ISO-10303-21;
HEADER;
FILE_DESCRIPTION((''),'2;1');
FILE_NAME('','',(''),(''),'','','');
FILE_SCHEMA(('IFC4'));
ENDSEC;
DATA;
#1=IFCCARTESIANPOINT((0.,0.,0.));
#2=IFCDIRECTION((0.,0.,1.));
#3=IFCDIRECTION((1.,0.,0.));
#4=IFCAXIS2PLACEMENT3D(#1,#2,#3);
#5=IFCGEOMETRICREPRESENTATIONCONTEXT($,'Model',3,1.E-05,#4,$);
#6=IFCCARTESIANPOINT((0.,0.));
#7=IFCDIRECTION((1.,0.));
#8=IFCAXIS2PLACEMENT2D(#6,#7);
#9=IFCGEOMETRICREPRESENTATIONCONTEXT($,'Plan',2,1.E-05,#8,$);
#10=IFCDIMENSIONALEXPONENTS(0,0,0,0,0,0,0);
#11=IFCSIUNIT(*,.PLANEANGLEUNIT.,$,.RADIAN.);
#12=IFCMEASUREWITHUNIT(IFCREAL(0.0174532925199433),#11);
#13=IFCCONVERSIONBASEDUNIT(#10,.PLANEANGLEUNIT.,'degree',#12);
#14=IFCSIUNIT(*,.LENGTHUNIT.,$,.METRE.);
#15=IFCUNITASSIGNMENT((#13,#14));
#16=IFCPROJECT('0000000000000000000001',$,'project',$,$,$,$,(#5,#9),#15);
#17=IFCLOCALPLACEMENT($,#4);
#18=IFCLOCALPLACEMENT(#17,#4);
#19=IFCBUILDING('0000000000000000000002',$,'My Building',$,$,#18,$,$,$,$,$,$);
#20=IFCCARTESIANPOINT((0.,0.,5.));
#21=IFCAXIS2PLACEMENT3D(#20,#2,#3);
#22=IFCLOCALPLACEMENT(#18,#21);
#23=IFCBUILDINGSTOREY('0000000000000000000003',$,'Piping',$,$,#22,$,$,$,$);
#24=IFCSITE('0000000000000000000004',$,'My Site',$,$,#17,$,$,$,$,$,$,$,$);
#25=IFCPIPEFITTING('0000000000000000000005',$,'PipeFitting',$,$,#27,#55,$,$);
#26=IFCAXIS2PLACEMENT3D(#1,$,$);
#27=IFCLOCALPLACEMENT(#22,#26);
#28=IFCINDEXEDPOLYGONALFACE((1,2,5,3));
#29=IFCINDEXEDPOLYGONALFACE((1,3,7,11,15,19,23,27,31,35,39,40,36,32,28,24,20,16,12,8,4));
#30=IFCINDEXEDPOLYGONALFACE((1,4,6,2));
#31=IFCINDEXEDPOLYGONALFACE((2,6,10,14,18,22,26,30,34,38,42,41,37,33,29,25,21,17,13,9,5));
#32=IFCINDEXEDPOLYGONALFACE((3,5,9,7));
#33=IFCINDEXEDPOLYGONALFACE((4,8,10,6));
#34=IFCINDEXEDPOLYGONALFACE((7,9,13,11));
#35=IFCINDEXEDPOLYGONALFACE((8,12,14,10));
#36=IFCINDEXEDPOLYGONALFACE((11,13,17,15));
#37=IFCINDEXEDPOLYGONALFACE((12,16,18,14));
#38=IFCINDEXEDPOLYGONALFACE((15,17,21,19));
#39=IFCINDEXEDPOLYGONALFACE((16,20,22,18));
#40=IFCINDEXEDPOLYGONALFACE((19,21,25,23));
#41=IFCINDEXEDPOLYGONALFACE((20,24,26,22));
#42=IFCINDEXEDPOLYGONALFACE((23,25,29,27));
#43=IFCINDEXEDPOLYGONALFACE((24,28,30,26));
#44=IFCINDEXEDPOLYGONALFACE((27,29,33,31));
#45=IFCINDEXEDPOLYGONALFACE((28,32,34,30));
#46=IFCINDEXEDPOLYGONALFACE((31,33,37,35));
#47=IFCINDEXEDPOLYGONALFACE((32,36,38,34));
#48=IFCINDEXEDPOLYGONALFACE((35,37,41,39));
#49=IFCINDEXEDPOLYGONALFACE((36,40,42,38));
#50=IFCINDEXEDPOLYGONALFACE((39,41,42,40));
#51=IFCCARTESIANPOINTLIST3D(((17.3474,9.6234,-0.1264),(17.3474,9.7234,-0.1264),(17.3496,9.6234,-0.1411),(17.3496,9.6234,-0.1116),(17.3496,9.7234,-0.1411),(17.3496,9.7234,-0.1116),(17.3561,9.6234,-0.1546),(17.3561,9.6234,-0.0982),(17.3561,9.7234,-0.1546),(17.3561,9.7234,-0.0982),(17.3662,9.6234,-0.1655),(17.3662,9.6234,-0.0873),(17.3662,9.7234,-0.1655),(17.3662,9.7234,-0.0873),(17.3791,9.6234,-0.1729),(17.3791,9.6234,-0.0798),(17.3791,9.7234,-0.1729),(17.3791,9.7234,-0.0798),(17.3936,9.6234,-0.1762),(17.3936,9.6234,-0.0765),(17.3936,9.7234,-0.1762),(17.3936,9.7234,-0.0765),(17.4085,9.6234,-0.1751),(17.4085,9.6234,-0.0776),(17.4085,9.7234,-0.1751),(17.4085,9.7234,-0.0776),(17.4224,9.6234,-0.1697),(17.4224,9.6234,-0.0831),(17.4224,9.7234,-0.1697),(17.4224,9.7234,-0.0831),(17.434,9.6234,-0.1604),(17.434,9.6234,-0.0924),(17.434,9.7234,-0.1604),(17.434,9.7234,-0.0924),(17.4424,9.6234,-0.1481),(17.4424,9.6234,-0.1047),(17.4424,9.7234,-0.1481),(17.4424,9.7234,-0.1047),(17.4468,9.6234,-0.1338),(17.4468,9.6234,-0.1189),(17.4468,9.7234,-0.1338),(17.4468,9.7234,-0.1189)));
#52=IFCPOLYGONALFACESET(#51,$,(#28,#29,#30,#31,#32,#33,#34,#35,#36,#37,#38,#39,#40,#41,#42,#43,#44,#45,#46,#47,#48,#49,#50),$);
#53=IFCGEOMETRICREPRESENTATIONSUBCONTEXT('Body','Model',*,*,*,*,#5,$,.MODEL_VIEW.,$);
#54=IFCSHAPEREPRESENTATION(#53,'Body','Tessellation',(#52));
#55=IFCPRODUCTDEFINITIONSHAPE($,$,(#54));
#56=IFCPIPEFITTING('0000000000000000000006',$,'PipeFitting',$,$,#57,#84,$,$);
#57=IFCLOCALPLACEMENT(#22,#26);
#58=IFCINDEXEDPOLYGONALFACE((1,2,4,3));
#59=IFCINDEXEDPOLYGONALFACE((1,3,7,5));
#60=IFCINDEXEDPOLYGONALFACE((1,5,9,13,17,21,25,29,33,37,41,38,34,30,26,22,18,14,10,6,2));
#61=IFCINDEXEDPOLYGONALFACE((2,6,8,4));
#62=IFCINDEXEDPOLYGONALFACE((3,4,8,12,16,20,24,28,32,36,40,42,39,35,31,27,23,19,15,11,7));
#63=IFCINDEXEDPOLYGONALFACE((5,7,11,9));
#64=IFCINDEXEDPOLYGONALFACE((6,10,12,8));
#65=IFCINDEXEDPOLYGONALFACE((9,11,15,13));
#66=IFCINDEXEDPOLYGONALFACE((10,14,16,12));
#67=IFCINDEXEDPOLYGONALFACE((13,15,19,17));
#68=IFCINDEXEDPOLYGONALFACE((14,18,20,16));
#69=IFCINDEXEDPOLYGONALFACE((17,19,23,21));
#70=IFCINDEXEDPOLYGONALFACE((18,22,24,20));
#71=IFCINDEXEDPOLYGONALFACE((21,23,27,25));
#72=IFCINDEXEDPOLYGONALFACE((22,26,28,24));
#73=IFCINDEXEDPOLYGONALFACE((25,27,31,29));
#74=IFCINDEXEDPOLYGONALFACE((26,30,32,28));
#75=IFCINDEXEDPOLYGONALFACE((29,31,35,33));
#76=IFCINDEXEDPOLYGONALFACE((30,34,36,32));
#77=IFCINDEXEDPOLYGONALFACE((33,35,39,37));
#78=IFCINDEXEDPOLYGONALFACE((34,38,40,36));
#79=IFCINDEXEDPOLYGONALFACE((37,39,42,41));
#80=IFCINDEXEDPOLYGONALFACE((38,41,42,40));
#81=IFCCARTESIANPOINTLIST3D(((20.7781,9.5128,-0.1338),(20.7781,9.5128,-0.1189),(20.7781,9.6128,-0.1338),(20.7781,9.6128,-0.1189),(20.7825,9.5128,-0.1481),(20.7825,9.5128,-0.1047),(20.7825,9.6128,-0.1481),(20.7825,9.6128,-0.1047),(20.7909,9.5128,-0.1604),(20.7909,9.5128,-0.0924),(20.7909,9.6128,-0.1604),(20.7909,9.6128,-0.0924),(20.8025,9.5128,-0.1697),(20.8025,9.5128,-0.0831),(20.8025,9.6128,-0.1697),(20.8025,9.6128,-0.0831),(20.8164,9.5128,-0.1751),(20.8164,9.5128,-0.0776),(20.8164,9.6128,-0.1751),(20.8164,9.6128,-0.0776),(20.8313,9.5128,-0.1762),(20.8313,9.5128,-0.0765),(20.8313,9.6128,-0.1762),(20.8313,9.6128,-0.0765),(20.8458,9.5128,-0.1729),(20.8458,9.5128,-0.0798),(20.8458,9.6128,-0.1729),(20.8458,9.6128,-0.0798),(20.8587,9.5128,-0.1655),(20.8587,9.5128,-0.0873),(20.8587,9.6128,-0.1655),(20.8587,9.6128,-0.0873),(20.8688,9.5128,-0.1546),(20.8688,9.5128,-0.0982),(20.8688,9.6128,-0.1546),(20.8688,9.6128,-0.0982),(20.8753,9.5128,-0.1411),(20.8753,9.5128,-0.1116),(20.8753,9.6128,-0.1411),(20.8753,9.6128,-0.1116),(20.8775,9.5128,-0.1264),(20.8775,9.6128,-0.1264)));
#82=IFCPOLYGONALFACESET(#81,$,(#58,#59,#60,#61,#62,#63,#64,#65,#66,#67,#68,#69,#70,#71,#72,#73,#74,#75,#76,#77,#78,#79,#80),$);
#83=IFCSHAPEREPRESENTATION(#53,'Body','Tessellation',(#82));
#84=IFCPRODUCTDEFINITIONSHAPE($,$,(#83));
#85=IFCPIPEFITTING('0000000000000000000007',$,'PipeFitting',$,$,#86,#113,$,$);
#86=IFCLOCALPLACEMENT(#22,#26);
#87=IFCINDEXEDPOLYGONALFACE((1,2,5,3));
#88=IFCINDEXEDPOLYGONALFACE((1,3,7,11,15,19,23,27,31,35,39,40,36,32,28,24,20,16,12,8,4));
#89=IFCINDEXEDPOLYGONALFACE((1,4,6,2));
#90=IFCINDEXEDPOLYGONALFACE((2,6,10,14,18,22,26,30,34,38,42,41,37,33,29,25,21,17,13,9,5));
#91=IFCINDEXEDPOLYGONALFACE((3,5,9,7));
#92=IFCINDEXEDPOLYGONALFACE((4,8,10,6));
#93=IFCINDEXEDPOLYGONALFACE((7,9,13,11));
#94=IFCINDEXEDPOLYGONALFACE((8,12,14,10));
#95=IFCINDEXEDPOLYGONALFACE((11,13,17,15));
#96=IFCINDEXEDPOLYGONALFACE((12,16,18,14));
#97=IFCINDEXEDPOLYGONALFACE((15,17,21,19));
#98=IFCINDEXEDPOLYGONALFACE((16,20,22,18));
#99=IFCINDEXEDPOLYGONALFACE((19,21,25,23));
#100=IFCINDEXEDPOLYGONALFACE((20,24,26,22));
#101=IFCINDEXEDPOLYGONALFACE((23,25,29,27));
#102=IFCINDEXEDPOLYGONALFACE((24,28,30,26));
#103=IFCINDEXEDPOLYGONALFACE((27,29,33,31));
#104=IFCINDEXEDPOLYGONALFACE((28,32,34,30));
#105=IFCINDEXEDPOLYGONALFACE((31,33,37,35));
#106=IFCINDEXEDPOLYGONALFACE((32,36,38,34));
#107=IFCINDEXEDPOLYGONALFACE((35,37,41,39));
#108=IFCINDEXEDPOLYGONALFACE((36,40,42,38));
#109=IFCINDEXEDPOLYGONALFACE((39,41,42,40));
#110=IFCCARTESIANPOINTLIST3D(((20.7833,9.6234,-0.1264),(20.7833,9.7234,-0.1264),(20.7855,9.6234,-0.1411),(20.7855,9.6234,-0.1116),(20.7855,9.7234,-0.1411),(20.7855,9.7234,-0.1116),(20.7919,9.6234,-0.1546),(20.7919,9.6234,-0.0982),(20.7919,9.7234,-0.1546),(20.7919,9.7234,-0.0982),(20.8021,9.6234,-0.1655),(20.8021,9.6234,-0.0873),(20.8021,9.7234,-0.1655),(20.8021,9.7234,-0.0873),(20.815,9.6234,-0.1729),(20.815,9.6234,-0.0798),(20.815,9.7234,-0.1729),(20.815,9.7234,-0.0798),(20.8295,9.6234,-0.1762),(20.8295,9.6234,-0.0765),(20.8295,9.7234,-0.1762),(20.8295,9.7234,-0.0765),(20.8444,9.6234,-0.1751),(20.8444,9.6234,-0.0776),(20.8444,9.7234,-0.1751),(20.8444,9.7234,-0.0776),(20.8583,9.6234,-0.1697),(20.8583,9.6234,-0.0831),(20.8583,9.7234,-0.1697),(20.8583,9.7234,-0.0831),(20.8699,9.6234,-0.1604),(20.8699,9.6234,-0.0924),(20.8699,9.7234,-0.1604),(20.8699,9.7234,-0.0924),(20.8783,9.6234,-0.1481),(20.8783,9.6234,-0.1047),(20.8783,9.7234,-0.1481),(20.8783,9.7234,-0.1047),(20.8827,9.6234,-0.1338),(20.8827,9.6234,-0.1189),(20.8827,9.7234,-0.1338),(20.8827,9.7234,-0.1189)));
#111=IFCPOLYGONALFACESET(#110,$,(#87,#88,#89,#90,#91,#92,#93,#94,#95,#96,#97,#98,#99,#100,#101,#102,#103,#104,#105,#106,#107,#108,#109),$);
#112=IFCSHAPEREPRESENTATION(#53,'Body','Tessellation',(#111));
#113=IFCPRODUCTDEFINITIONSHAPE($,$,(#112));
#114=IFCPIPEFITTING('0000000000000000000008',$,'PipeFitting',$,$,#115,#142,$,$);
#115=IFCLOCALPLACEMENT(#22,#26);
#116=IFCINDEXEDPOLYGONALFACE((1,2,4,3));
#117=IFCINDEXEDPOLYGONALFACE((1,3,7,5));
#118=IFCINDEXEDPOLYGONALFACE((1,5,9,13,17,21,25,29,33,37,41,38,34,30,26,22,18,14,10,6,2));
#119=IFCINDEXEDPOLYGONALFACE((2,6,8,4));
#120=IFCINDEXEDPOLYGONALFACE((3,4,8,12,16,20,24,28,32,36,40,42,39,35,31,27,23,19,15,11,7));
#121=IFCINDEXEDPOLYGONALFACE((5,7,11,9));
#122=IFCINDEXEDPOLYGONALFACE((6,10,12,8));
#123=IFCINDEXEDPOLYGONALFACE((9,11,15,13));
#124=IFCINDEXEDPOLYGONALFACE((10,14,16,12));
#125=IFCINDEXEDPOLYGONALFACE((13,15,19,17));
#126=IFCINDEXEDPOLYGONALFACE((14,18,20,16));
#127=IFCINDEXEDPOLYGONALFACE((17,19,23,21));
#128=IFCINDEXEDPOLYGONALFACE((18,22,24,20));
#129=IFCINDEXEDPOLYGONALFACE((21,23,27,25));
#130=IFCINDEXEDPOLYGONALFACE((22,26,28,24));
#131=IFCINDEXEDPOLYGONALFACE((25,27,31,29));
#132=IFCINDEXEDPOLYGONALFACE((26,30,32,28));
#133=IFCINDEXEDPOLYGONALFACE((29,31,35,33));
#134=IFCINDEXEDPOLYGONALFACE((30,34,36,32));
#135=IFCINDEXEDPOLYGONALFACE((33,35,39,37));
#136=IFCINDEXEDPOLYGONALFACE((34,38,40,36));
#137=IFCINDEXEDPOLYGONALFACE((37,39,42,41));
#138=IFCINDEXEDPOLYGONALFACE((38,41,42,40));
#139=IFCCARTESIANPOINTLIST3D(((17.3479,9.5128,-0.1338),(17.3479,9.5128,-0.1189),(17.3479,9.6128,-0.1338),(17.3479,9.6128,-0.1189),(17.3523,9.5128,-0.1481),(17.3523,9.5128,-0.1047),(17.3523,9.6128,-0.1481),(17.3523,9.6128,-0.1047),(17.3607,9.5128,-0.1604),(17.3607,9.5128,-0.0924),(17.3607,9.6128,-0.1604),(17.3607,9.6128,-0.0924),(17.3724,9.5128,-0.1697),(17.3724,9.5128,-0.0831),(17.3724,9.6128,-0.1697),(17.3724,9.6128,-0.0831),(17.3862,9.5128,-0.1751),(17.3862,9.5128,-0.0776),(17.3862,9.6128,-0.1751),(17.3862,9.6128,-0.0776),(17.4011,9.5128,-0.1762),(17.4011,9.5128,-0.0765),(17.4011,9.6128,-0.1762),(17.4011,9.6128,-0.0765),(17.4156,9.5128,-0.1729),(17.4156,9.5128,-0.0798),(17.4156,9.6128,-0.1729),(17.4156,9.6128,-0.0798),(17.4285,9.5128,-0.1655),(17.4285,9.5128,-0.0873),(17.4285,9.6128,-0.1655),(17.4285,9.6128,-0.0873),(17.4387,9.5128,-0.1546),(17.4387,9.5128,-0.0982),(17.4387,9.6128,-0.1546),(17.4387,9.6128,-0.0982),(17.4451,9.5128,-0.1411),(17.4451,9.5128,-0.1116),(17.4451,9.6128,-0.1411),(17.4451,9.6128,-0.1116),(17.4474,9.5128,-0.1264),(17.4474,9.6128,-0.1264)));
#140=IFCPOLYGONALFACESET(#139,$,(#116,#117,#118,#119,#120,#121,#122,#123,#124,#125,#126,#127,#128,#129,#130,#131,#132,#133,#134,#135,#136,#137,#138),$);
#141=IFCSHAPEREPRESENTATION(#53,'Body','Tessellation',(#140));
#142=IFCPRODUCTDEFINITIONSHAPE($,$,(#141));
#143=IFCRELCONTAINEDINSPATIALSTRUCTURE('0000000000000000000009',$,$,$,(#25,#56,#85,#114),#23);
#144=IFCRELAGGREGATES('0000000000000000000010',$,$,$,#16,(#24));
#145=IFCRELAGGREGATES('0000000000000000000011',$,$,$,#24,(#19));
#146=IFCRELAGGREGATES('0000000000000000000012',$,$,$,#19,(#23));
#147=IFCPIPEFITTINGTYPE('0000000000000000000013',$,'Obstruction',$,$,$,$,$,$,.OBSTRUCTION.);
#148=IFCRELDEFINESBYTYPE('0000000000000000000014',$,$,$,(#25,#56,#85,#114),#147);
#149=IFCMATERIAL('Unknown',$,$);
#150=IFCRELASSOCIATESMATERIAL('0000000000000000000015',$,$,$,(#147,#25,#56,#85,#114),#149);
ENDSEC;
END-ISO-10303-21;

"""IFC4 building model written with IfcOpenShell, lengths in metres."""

from ifc_helpers import new_model, entity, si_unit, converted_unit, frame, origin_with_axes, origin_2d_with_axis, place, context, subcontext, project, spatial, circle, extrude, material, material_profile, profile_set, profile_usage, type_object, element, save


model = new_model("IFC4")

# Units and contexts
model_context = context("Model", 3, precision=1e-05, world=origin_with_axes())
plan_context = context("Plan", 2, precision=1e-05, world=origin_2d_with_axis())
body_context = subcontext(model_context, "Body", "Model", "MODEL_VIEW")
ifc_project = project(units=[converted_unit("PLANEANGLEUNIT", "degree", entity("IfcReal", 0.0174532925199433), si_unit("PLANEANGLEUNIT", "RADIAN"), dimensions=[0, 0, 0, 0, 0, 0, 0]), si_unit("LENGTHUNIT", "METRE")], contexts=[model_context, plan_context])

# Site, building, storey
site_placement = place(None, origin_with_axes())
site = spatial("IfcSite", under=ifc_project, at=site_placement, Name="My Site")
building_placement = place(site_placement, origin_with_axes())
building = spatial("IfcBuilding", under=site, at=building_placement, Name="My Building")
storey_placement = place(building_placement, frame((0.0, 0.0, 5.0), z_axis=(0.0, 0.0, 1.0), x_axis=(1.0, 0.0, 0.0)))
storey = spatial("IfcBuildingStorey", under=building, at=storey_placement, Name="Piping")

# Shared definitions
ifc_material = material(Name="Unknown")

# Pipe fittings
ifc_material_profile_1 = material_profile(ifc_material, circle(Radius=0.05))
ifc_profile_set_1 = profile_set([ifc_material_profile_1])
pipe_fitting_type_1 = type_object("IfcPipeFittingType", Name="Obstruction", PredefinedType="OBSTRUCTION", material=ifc_profile_set_1)
ifc_profile_usage_1 = profile_usage(ifc_profile_set_1, cardinal=5)
pipe_fitting_1_placement = place(storey_placement, frame((17.3974, 9.6234, -0.1264), z_axis=(0.0, 1.0, 0.0), x_axis=(-1.0, 0.0, 0.0)))
element("IfcPipeFitting", 1, at=pipe_fitting_1_placement, inside=storey, type_object=pipe_fitting_type_1, material=ifc_profile_usage_1, Name="PipeFitting", context=body_context, shape_type="SweptSolid", body=[
    extrude(circle(Radius=0.05), origin_with_axes(), (0.0, 0.0, 1.0), 0.1),
])
ifc_profile_usage_2 = profile_usage(ifc_profile_set_1, cardinal=5)
pipe_fitting_2_placement = place(storey_placement, frame((20.8275, 9.6128, -0.1264), z_axis=(0.0, -1.0, 0.0), x_axis=(1.0, 0.0, 0.0)))
element("IfcPipeFitting", 2, at=pipe_fitting_2_placement, inside=storey, type_object=pipe_fitting_type_1, material=ifc_profile_usage_2, Name="PipeFitting", context=body_context, shape_type="SweptSolid", body=[
    extrude(circle(Radius=0.05), origin_with_axes(), (0.0, 0.0, 1.0), 0.1),
])
ifc_profile_usage_3 = profile_usage(ifc_profile_set_1, cardinal=5)
pipe_fitting_3_placement = place(storey_placement, frame((20.8333, 9.6234, -0.1264), z_axis=(0.0, 1.0, 0.0), x_axis=(-1.0, 0.0, 0.0)))
element("IfcPipeFitting", 3, at=pipe_fitting_3_placement, inside=storey, type_object=pipe_fitting_type_1, material=ifc_profile_usage_3, Name="PipeFitting", context=body_context, shape_type="SweptSolid", body=[
    extrude(circle(Radius=0.05), origin_with_axes(), (0.0, 0.0, 1.0), 0.1),
])
ifc_profile_usage_4 = profile_usage(ifc_profile_set_1, cardinal=5)
pipe_fitting_4_placement = place(storey_placement, frame((17.3974, 9.6128, -0.1264), z_axis=(0.0, -1.0, 0.0), x_axis=(1.0, 0.0, 0.0)))
element("IfcPipeFitting", 4, at=pipe_fitting_4_placement, inside=storey, type_object=pipe_fitting_type_1, material=ifc_profile_usage_4, Name="PipeFitting", context=body_context, shape_type="SweptSolid", body=[
    extrude(circle(Radius=0.05), origin_with_axes(), (0.0, 0.0, 1.0), 0.1),
])

save(model, "model.ifc")
